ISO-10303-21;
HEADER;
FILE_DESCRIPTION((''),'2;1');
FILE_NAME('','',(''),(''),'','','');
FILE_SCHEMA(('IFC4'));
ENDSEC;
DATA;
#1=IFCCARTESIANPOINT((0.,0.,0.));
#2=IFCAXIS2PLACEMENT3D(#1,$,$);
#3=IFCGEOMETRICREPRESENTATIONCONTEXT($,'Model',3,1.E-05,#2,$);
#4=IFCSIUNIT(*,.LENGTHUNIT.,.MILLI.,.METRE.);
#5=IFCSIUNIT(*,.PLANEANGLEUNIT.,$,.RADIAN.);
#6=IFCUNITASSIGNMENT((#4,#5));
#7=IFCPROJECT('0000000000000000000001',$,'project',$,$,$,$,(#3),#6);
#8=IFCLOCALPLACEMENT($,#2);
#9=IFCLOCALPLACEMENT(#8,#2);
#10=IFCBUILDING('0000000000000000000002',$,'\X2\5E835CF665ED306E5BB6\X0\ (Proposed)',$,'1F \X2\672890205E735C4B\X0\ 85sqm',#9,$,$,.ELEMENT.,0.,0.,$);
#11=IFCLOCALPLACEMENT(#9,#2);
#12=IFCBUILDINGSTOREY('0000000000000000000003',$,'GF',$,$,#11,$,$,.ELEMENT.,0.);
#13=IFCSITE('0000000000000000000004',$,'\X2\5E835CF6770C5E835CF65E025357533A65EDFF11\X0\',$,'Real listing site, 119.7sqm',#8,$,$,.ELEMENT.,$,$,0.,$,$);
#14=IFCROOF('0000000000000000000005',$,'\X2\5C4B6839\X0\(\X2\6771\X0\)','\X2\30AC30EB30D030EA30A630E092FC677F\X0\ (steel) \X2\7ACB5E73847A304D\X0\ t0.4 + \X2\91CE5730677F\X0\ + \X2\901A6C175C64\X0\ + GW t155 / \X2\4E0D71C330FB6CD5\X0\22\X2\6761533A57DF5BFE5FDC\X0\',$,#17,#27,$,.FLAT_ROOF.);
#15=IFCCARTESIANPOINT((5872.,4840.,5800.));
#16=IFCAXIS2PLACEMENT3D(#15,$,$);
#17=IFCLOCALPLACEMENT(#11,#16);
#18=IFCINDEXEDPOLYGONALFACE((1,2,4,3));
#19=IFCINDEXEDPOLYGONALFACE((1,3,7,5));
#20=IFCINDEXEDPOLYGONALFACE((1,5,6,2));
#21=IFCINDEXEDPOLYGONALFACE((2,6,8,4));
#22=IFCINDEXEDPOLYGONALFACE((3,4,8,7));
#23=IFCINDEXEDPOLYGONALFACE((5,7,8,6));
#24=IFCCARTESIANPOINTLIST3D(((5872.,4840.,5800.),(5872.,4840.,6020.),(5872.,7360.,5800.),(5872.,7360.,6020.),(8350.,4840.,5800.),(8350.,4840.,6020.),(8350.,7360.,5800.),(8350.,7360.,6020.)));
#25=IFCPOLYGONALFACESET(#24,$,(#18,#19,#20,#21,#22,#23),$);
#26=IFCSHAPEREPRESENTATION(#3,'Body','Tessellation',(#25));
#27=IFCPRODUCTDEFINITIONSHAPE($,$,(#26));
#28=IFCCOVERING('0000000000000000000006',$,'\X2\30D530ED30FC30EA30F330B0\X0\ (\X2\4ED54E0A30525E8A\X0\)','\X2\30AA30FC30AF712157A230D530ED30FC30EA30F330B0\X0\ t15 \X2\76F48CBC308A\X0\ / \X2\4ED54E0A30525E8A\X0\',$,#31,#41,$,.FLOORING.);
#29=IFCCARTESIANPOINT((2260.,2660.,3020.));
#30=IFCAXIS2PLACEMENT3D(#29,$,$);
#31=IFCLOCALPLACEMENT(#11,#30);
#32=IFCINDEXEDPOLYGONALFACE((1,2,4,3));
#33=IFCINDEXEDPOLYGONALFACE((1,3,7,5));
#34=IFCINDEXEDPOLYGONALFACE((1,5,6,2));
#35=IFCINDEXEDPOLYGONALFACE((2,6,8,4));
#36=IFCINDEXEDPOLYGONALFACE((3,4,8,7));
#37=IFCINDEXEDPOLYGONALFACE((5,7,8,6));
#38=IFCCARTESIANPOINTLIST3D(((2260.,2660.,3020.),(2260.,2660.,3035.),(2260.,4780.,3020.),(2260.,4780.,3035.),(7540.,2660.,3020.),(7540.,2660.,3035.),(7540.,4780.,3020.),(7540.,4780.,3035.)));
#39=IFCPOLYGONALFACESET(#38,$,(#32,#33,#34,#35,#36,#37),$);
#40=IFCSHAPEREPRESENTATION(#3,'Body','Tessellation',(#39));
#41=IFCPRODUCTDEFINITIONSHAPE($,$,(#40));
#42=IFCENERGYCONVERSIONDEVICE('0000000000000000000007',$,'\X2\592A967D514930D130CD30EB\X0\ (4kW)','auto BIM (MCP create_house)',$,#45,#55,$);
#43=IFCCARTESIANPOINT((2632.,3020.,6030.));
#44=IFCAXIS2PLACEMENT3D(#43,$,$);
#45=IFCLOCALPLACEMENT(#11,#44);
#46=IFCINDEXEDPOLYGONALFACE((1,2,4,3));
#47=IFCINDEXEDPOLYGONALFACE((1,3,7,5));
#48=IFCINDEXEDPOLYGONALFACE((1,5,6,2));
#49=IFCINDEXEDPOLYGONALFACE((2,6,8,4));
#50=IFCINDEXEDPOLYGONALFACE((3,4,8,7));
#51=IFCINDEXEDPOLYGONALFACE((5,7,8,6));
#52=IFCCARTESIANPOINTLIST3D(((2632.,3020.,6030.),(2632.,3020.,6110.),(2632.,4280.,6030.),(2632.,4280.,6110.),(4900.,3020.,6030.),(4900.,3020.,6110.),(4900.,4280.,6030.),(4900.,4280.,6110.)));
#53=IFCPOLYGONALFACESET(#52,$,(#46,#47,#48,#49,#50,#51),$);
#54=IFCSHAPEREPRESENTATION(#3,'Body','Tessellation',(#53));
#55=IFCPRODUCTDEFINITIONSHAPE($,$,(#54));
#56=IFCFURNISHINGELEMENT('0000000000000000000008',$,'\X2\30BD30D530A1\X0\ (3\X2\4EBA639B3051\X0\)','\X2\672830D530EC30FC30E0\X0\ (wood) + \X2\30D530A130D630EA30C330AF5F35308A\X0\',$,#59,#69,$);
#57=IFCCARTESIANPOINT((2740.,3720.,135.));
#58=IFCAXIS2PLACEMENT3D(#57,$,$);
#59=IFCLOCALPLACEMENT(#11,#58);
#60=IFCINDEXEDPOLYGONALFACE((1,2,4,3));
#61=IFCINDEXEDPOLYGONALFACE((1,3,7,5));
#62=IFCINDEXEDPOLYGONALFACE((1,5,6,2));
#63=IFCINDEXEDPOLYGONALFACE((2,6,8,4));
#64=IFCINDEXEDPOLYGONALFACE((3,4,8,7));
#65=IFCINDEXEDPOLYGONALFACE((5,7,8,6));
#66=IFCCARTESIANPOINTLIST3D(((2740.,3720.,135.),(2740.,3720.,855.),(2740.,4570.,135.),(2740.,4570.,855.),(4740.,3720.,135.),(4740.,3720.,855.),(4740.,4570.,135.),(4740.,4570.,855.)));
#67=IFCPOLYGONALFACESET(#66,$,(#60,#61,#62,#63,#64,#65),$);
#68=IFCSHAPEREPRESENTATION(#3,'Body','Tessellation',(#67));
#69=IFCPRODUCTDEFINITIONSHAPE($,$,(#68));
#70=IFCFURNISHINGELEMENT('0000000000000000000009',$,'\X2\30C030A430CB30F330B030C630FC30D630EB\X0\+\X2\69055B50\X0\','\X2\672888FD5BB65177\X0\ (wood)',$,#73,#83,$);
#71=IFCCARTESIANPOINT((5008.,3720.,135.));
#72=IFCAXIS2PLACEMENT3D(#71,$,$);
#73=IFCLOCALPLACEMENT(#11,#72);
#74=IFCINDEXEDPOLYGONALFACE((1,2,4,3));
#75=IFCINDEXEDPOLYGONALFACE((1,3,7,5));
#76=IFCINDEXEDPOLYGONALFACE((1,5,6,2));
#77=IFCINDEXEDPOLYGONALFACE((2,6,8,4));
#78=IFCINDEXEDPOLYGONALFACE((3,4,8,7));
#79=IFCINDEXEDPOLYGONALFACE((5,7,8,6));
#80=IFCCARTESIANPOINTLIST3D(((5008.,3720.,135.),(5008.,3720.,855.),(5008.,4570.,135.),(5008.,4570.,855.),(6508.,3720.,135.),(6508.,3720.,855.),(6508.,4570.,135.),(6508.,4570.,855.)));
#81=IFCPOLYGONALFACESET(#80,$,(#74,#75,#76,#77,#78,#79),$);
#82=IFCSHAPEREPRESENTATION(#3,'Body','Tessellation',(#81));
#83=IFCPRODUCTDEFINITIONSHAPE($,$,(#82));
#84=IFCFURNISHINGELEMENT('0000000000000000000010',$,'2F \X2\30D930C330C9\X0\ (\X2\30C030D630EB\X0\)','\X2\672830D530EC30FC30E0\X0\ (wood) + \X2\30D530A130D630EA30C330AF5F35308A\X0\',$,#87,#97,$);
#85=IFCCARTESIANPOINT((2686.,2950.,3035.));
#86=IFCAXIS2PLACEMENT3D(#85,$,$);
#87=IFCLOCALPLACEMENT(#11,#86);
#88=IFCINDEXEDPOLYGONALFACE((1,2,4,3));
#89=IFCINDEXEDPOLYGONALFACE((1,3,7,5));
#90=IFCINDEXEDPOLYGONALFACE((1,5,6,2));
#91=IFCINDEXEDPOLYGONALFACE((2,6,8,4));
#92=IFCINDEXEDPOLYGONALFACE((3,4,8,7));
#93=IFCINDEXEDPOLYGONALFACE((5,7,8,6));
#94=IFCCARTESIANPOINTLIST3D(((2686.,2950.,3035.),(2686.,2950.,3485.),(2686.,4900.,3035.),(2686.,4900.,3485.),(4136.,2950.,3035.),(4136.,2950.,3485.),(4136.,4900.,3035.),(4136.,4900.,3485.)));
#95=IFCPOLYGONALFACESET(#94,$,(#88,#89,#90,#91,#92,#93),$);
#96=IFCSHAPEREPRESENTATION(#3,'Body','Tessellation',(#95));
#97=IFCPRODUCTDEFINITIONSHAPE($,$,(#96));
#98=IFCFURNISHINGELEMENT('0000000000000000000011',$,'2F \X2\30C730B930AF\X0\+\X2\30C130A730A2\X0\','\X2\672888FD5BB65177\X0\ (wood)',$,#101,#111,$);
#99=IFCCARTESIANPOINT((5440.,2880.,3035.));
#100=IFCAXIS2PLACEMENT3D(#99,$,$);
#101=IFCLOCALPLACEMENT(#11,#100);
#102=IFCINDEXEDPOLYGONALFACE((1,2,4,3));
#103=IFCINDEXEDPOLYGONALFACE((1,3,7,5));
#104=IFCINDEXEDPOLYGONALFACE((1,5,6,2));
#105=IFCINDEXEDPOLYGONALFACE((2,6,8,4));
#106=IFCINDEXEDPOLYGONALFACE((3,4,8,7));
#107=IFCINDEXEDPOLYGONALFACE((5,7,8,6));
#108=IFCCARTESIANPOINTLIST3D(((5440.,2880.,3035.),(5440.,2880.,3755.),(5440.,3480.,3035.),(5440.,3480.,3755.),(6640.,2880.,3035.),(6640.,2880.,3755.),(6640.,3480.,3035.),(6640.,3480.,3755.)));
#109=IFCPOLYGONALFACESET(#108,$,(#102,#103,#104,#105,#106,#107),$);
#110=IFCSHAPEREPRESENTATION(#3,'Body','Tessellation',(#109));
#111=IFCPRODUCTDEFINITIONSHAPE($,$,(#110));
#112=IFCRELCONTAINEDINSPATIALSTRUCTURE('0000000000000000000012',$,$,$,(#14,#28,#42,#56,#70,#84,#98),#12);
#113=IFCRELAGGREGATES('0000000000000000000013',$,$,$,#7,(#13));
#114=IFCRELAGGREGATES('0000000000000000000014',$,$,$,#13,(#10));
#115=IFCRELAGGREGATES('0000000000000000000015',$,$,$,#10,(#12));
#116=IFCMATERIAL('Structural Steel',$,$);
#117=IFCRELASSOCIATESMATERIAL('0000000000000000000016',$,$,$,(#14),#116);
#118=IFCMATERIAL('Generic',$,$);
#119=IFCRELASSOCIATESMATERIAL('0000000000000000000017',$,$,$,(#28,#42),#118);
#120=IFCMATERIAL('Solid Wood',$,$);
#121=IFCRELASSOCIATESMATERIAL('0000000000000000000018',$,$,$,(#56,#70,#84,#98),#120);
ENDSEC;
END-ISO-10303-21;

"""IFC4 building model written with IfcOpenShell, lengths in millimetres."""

from ifc_helpers import new_model, si_unit, frame, frame_2d, origin, place, context, project, spatial, rectangle, extrude, material, element, save


model = new_model("IFC4")

# Units and contexts
model_context = context("Model", 3, precision=1e-05, world=origin())
ifc_project = project(units=[si_unit("LENGTHUNIT", "METRE", prefix="MILLI"), si_unit("PLANEANGLEUNIT", "RADIAN")], contexts=[model_context])

# Site, building, storey
site_placement = place(None, origin())
site = spatial("IfcSite", under=ifc_project, at=site_placement, Name="広島県広島市南区旭１", ObjectType="Real listing site, 119.7sqm", CompositionType="ELEMENT", RefElevation=0.0)
building_placement = place(site_placement, origin())
building = spatial("IfcBuilding", under=site, at=building_placement, Name="広島旭の家 (Proposed)", ObjectType="1F 木造平屋 85sqm", CompositionType="ELEMENT", ElevationOfRefHeight=0.0, ElevationOfTerrain=0.0)
storey_placement = place(building_placement, origin())
storey = spatial("IfcBuildingStorey", under=building, at=storey_placement, Name="GF", CompositionType="ELEMENT", Elevation=0.0)

# Shared definitions
ifc_material_1 = material(Name="Solid Wood")

# Roof
ifc_material_2 = material(Name="Structural Steel")
roof_1_placement = place(storey_placement, frame((5872.0, 4840.0, 5800.0)))
element("IfcRoof", 1, at=roof_1_placement, inside=storey, material=ifc_material_2, Name="屋根(東)", Description="ガルバリウム鋼板 (steel) 立平葺き t0.4 + 野地板 + 通気層 + GW t155 / 不燃・法22条区域対応", PredefinedType="FLAT_ROOF", context=model_context, shape_type="SweptSolid", body=[
    extrude(rectangle(XDim=2478.0, YDim=2520.0, at=frame_2d((1239.0, 1260.0))), frame((5872.0, 4840.0, 5800.0)), (0.0, 0.0, 1.0), 220.0),
])

# Covering
ifc_material_3 = material(Name="Generic")
covering_placement = place(storey_placement, frame((2260.0, 2660.0, 3020.0)))
element("IfcCovering", 2, at=covering_placement, inside=storey, material=ifc_material_3, Name="フローリング (仕上げ床)", Description="オーク無垢フローリング t15 直貼り / 仕上げ床", PredefinedType="FLOORING", context=model_context, shape_type="SweptSolid", body=[
    extrude(rectangle(XDim=5280.0, YDim=2120.0, at=frame_2d((2640.0, 1060.0))), frame((2260.0, 2660.0, 3020.0)), (0.0, 0.0, 1.0), 15.0),
])

# Energy conversion device
energy_conversion_device_placement = place(storey_placement, frame((2632.0, 3020.0, 6030.0)))
element("IfcEnergyConversionDevice", 3, at=energy_conversion_device_placement, inside=storey, material=ifc_material_3, Name="太陽光パネル (4kW)", Description="auto BIM (MCP create_house)", context=model_context, shape_type="SweptSolid", body=[
    extrude(rectangle(XDim=2268.0, YDim=1260.0, at=frame_2d((1134.0, 630.0))), frame((2632.0, 3020.0, 6030.0)), (0.0, 0.0, 1.0), 80.0),
])

# Furnishing elements
furnishing_1_placement = place(storey_placement, frame((2740.0, 3720.0, 135.0)))
element("IfcFurnishingElement", 4, at=furnishing_1_placement, inside=storey, material=ifc_material_1, Name="ソファ (3人掛け)", Description="木フレーム (wood) + ファブリック張り", context=model_context, shape_type="SweptSolid", body=[
    extrude(rectangle(XDim=2000.0, YDim=850.0, at=frame_2d((1000.0, 425.0))), frame((2740.0, 3720.0, 135.0)), (0.0, 0.0, 1.0), 720.0),
])
furnishing_2_placement = place(storey_placement, frame((5008.0, 3720.0, 135.0)))
element("IfcFurnishingElement", 5, at=furnishing_2_placement, inside=storey, material=ifc_material_1, Name="ダイニングテーブル+椅子", Description="木製家具 (wood)", context=model_context, shape_type="SweptSolid", body=[
    extrude(rectangle(XDim=1500.0, YDim=850.0, at=frame_2d((750.0, 425.0))), frame((5008.0, 3720.0, 135.0)), (0.0, 0.0, 1.0), 720.0),
])
furnishing_3_placement = place(storey_placement, frame((2686.0, 2950.0, 3035.0)))
element("IfcFurnishingElement", 6, at=furnishing_3_placement, inside=storey, material=ifc_material_1, Name="2F ベッド (ダブル)", Description="木フレーム (wood) + ファブリック張り", context=model_context, shape_type="SweptSolid", body=[
    extrude(rectangle(XDim=1450.0, YDim=1950.0, at=frame_2d((725.0, 975.0))), frame((2686.0, 2950.0, 3035.0)), (0.0, 0.0, 1.0), 450.0),
])
furnishing_4_placement = place(storey_placement, frame((5440.0, 2880.0, 3035.0)))
element("IfcFurnishingElement", 7, at=furnishing_4_placement, inside=storey, material=ifc_material_1, Name="2F デスク+チェア", Description="木製家具 (wood)", context=model_context, shape_type="SweptSolid", body=[
    extrude(rectangle(XDim=1200.0, YDim=600.0, at=frame_2d((600.0, 300.0))), frame((5440.0, 2880.0, 3035.0)), (0.0, 0.0, 1.0), 720.0),
])

save(model, "model.ifc")
